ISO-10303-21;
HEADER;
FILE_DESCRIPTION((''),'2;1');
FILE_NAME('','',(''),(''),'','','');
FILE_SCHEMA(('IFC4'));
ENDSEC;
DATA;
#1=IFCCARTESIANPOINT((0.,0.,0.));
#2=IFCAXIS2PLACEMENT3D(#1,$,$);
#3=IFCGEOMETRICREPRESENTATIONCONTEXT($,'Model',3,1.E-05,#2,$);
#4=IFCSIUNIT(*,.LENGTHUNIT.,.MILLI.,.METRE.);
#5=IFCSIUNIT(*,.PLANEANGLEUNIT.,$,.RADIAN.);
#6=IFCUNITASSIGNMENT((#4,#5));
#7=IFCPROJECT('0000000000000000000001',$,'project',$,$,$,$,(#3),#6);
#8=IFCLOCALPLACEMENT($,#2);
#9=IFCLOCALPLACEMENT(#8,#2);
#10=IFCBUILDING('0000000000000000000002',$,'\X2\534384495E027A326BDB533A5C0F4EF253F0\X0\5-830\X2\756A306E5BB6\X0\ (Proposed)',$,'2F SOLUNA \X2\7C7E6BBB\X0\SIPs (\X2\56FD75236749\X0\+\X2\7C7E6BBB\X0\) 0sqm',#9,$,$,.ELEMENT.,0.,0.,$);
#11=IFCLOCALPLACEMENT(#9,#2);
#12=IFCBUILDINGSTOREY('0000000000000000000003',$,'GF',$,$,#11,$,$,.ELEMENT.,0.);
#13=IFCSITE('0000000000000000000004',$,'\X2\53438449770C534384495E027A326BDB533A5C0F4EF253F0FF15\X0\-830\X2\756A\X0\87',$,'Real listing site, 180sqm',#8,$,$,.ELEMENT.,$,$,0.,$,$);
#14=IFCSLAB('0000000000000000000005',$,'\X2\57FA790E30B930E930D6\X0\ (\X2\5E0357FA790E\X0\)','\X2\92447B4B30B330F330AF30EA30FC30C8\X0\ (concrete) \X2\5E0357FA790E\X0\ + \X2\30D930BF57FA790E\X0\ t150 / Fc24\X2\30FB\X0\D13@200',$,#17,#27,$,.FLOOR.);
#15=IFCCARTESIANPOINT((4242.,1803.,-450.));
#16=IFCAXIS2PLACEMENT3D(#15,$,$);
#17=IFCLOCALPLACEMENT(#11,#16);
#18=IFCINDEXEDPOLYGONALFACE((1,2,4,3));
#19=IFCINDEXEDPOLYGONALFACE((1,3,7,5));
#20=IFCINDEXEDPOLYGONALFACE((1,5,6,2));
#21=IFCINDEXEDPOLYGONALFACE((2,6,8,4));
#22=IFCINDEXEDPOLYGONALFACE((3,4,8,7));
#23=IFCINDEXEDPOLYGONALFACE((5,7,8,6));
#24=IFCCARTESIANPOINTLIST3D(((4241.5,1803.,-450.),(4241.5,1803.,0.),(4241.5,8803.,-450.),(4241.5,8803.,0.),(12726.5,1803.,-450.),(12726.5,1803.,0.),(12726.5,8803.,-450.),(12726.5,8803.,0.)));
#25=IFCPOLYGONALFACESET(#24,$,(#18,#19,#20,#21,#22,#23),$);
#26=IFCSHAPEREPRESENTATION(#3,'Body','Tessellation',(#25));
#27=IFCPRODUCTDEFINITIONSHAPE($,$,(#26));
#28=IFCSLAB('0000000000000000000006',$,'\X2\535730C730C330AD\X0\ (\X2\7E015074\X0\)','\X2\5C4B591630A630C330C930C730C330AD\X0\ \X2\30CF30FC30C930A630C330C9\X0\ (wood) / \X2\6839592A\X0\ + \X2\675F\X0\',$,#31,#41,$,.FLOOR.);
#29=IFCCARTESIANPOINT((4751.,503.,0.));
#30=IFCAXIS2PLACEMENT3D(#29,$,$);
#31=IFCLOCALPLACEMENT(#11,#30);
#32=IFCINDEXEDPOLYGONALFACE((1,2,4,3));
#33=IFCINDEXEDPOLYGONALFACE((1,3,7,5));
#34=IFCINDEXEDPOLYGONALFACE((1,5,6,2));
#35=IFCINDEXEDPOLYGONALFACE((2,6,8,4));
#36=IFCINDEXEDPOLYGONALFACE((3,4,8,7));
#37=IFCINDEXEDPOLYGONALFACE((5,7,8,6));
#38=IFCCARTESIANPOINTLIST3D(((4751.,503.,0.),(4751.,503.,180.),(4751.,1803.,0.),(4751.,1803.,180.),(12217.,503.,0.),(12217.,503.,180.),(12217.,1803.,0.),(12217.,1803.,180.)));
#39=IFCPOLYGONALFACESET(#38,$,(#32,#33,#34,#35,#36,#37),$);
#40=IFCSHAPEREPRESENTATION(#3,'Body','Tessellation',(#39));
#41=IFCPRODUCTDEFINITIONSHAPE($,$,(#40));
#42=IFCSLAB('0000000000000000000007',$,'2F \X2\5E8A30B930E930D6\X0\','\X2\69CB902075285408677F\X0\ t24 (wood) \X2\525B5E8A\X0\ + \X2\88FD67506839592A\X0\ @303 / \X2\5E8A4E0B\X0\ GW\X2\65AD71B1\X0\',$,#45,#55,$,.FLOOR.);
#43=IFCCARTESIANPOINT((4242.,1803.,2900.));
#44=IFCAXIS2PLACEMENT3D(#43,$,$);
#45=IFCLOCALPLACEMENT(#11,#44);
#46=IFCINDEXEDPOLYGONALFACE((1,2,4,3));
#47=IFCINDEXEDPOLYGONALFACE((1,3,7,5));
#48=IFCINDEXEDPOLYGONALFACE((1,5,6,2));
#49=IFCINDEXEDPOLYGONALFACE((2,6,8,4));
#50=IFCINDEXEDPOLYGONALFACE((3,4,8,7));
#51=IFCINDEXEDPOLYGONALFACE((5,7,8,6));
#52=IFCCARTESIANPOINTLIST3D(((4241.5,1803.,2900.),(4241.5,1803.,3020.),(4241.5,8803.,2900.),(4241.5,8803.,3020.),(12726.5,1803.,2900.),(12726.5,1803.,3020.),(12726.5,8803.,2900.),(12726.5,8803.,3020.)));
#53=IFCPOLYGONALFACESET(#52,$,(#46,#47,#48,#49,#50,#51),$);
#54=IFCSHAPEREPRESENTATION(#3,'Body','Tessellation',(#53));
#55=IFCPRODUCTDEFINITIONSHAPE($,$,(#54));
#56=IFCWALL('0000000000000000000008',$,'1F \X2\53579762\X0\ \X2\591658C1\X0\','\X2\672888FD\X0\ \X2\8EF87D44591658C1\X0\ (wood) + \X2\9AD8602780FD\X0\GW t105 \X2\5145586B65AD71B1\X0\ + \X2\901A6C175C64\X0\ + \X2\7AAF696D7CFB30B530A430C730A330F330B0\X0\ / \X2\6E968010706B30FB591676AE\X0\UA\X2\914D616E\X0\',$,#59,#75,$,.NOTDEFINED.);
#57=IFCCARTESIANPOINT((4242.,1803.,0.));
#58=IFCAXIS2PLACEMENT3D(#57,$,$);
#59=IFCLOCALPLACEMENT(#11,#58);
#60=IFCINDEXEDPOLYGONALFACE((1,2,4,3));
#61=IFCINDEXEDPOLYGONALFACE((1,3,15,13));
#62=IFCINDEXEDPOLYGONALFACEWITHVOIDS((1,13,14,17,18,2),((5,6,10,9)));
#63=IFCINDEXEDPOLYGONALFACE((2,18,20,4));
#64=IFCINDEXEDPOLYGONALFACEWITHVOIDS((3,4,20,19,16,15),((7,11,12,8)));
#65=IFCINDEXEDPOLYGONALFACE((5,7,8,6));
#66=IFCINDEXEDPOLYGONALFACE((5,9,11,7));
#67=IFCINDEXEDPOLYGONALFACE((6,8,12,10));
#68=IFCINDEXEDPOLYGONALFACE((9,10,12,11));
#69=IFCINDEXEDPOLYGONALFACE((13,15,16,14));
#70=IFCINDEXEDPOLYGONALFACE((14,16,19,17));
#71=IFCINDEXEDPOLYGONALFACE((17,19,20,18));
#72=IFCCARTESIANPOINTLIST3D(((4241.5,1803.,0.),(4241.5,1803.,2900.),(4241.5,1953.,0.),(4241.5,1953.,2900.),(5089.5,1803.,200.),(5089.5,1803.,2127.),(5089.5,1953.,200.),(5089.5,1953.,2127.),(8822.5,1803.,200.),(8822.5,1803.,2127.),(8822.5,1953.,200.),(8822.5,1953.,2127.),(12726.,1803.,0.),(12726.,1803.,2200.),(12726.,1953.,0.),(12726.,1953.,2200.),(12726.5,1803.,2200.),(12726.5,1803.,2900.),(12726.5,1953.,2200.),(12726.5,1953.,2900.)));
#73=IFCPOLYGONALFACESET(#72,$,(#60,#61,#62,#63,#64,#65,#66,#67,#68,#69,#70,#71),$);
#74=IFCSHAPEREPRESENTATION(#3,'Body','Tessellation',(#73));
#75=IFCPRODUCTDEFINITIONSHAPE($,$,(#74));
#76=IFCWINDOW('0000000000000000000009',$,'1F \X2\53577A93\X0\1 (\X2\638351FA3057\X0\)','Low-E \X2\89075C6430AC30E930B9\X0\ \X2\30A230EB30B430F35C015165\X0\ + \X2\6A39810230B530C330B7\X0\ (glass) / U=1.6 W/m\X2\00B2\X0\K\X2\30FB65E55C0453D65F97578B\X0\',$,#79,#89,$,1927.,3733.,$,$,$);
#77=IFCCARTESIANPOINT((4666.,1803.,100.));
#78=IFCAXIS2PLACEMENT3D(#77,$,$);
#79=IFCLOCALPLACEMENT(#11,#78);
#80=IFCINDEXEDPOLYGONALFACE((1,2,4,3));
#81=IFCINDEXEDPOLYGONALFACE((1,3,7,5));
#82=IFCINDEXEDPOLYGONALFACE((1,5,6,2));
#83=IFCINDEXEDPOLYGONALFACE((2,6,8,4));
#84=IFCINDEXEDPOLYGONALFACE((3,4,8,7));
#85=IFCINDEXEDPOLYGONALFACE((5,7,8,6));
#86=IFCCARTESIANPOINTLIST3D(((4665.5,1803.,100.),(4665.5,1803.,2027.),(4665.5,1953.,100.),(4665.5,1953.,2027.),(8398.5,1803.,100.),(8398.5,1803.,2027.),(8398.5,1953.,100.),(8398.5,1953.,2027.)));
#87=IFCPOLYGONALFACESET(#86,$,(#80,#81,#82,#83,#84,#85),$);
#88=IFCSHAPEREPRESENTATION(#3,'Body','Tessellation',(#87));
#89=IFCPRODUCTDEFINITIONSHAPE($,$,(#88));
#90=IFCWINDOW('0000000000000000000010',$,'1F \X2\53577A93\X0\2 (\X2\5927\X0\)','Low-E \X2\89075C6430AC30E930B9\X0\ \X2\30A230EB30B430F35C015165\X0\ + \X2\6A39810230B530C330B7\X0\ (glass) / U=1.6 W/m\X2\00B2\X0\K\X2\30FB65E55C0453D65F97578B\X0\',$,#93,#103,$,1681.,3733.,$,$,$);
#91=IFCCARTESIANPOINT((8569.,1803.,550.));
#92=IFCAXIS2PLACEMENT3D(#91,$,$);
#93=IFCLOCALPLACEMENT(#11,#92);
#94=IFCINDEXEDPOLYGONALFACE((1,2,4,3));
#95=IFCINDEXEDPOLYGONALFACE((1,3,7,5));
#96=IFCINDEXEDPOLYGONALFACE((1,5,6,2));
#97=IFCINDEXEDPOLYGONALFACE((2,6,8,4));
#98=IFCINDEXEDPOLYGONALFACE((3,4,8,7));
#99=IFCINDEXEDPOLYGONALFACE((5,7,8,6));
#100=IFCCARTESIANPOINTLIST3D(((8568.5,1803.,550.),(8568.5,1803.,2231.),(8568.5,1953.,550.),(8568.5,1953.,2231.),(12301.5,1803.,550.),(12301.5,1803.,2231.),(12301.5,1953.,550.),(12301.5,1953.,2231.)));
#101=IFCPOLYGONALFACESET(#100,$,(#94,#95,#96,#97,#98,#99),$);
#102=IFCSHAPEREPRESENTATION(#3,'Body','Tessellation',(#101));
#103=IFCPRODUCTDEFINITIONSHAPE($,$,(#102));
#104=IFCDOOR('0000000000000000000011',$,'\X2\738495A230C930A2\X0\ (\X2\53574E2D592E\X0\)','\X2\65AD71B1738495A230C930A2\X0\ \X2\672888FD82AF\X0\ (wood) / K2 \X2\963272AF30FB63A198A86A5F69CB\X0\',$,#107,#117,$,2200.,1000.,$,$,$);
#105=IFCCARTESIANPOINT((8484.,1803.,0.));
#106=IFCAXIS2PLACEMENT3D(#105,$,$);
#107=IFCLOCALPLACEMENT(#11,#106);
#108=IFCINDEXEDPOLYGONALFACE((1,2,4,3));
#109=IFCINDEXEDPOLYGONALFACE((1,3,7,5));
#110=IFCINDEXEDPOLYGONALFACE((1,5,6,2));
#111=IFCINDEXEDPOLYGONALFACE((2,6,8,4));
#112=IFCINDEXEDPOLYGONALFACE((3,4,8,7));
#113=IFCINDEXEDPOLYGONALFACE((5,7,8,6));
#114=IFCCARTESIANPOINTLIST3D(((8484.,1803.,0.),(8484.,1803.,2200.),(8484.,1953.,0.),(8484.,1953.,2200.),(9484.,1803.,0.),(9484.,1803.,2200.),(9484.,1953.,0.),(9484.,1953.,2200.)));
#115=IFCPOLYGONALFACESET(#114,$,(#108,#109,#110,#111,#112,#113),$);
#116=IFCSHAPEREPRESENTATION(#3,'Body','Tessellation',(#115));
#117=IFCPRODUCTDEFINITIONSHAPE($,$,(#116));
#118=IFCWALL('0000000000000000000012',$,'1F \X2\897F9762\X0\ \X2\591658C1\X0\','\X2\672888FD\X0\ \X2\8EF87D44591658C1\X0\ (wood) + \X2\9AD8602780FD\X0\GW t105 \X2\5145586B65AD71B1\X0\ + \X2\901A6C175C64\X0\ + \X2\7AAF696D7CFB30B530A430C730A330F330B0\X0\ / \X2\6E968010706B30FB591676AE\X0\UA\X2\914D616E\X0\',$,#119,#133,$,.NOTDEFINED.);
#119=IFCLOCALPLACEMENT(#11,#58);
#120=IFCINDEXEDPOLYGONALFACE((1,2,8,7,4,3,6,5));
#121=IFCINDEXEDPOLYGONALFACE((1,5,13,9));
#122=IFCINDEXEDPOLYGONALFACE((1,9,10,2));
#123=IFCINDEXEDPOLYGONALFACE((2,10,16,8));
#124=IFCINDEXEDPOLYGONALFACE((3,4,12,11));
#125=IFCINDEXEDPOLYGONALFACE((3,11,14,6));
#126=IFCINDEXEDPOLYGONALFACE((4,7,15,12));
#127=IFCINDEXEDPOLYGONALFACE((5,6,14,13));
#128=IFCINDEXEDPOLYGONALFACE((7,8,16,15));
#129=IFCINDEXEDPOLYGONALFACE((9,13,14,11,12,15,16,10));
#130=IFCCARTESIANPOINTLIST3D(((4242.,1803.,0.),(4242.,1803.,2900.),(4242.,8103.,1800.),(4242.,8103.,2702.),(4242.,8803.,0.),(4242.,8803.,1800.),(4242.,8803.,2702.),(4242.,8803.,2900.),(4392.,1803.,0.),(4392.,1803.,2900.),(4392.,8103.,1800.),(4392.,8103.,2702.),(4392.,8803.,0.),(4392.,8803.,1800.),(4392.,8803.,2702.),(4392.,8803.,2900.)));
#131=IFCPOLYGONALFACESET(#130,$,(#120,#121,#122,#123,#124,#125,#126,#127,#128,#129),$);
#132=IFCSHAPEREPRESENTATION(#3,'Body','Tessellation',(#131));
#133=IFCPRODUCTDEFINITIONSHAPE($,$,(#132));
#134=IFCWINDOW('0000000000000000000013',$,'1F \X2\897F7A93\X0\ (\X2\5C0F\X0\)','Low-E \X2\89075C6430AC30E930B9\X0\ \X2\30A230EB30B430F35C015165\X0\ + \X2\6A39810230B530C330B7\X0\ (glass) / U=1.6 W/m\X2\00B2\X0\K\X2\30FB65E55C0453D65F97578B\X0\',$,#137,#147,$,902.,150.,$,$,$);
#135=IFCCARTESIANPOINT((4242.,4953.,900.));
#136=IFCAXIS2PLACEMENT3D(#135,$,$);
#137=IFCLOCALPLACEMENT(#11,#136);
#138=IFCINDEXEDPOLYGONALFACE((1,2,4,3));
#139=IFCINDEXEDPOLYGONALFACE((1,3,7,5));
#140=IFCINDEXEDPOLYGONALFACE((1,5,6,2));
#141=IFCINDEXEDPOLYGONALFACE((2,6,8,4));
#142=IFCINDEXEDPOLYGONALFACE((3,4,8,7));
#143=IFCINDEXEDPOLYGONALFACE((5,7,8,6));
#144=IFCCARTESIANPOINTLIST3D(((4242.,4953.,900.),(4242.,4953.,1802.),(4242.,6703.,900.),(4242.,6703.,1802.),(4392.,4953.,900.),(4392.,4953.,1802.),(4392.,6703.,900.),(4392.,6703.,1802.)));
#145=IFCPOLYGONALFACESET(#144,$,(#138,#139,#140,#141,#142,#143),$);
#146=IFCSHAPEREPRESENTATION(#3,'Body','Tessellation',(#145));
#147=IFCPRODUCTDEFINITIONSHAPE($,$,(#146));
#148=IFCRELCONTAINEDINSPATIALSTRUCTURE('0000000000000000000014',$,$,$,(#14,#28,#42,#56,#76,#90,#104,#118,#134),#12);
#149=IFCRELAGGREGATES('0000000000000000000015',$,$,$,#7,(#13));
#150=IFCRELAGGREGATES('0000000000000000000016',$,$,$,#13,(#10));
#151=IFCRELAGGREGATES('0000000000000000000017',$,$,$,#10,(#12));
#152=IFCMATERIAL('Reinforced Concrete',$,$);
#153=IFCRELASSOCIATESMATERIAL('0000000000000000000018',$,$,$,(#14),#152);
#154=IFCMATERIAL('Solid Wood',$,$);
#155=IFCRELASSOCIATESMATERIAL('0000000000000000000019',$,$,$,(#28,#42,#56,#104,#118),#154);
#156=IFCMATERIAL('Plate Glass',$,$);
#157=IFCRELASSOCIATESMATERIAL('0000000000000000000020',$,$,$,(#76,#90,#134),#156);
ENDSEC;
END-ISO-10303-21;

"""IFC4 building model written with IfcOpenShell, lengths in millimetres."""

from ifc_helpers import new_model, si_unit, frame, frame_2d, origin, place, context, project, spatial, rectangle, extrude, material, element, fill, save


model = new_model("IFC4")

# Units and contexts
model_context = context("Model", 3, precision=1e-05, world=origin())
ifc_project = project(units=[si_unit("LENGTHUNIT", "METRE", prefix="MILLI"), si_unit("PLANEANGLEUNIT", "RADIAN")], contexts=[model_context])

# Site, building, storey
site_placement = place(None, origin())
site = spatial("IfcSite", under=ifc_project, at=site_placement, Name="千葉県千葉市稲毛区小仲台５-830番87", ObjectType="Real listing site, 180sqm", CompositionType="ELEMENT", RefElevation=0.0)
building_placement = place(site_placement, origin())
building = spatial("IfcBuilding", under=site, at=building_placement, Name="千葉市稲毛区小仲台5-830番の家 (Proposed)", ObjectType="2F SOLUNA 籾殻SIPs (国産杉+籾殻) 0sqm", CompositionType="ELEMENT", ElevationOfRefHeight=0.0, ElevationOfTerrain=0.0)
storey_placement = place(building_placement, origin())
storey = spatial("IfcBuildingStorey", under=building, at=storey_placement, Name="GF", CompositionType="ELEMENT", Elevation=0.0)

# Slabs
ifc_material_1 = material(Name="Reinforced Concrete")
slab_1_placement = place(storey_placement, frame((4242.0, 1803.0, -450.0)))
element("IfcSlab", 1, at=slab_1_placement, inside=storey, material=ifc_material_1, Name="基礎スラブ (布基礎)", Description="鉄筋コンクリート (concrete) 布基礎 + ベタ基礎 t150 / Fc24・D13@200", PredefinedType="FLOOR", context=model_context, shape_type="SweptSolid", body=[
    extrude(rectangle(XDim=8485.0, YDim=7000.0, at=frame_2d((4242.0, 3500.0))), frame((4242.0, 1803.0, -450.0)), (0.0, 0.0, 1.0), 450.0),
])
ifc_material_2 = material(Name="Solid Wood")
slab_2_placement = place(storey_placement, frame((4751.0, 503.0, 0.0)))
element("IfcSlab", 2, at=slab_2_placement, inside=storey, material=ifc_material_2, Name="南デッキ (縁側)", Description="屋外ウッドデッキ ハードウッド (wood) / 根太 + 束", PredefinedType="FLOOR", context=model_context, shape_type="SweptSolid", body=[
    extrude(rectangle(XDim=7466.0, YDim=1300.0, at=frame_2d((3733.0, 650.0))), frame((4751.0, 503.0, 0.0)), (0.0, 0.0, 1.0), 180.0),
])
slab_3_placement = place(storey_placement, frame((4242.0, 1803.0, 2900.0)))
element("IfcSlab", 3, at=slab_3_placement, inside=storey, material=ifc_material_2, Name="2F 床スラブ", Description="構造用合板 t24 (wood) 剛床 + 製材根太 @303 / 床下 GW断熱", PredefinedType="FLOOR", context=model_context, shape_type="SweptSolid", body=[
    extrude(rectangle(XDim=8485.0, YDim=7000.0, at=frame_2d((4242.0, 3500.0))), frame((4242.0, 1803.0, 2900.0)), (0.0, 0.0, 1.0), 120.0),
])

# Wall, openings, windows, door
wall_1_placement = place(storey_placement, frame((4242.0, 1803.0, 0.0)))
wall_1 = element("IfcWall", 4, at=wall_1_placement, inside=storey, material=ifc_material_2, Name="1F 南面 外壁", Description="木製 軸組外壁 (wood) + 高性能GW t105 充填断熱 + 通気層 + 窯業系サイディング / 準耐火・外皮UA配慮", PredefinedType="NOTDEFINED", context=model_context, shape_type="SweptSolid", body=[
    extrude(rectangle(XDim=8485.0, YDim=150.0, at=frame_2d((4242.0, 75.0))), frame((4242.0, 1803.0, 0.0)), (0.0, 0.0, 1.0), 2900.0),
])
opening_1_placement = place(storey_placement, frame((4666.0, 1803.0, 100.0)))
opening_1 = element("IfcOpeningElement", 5, at=opening_1_placement, cuts=wall_1, PredefinedType="NOTDEFINED", context=model_context, shape_type="SweptSolid", body=[
    extrude(rectangle(XDim=3733.0, YDim=150.0, at=frame_2d((1866.0, 75.0))), frame((4666.0, 1803.0, 100.0)), (0.0, 0.0, 1.0), 1927.0),
])
opening_2_placement = place(storey_placement, frame((8569.0, 1803.0, 550.0)))
opening_2 = element("IfcOpeningElement", 6, at=opening_2_placement, cuts=wall_1, PredefinedType="NOTDEFINED", context=model_context, shape_type="SweptSolid", body=[
    extrude(rectangle(XDim=3733.0, YDim=150.0, at=frame_2d((1866.0, 75.0))), frame((8569.0, 1803.0, 550.0)), (0.0, 0.0, 1.0), 1681.0),
])
opening_3_placement = place(storey_placement, frame((8484.0, 1803.0, 0.0)))
opening_3 = element("IfcOpeningElement", 7, at=opening_3_placement, cuts=wall_1, PredefinedType="NOTDEFINED", context=model_context, shape_type="SweptSolid", body=[
    extrude(rectangle(XDim=1000.0, YDim=150.0, at=frame_2d((500.0, 75.0))), frame((8484.0, 1803.0, 0.0)), (0.0, 0.0, 1.0), 2200.0),
])
ifc_material_3 = material(Name="Plate Glass")
window_1_placement = place(storey_placement, frame((4666.0, 1803.0, 100.0)))
window_1 = element("IfcWindow", 8, at=window_1_placement, inside=storey, material=ifc_material_3, Name="1F 南窓1 (掃出し)", Description="Low-E 複層ガラス アルゴン封入 + 樹脂サッシ (glass) / U=1.6 W/m²K・日射取得型", OverallHeight=1927.0, OverallWidth=3733.0, context=model_context, shape_type="SweptSolid", body=[
    extrude(rectangle(XDim=3733.0, YDim=150.0, at=frame_2d((1866.0, 75.0))), frame((4666.0, 1803.0, 100.0)), (0.0, 0.0, 1.0), 1927.0),
])
fill(opening_1, window_1)
window_2_placement = place(storey_placement, frame((8569.0, 1803.0, 550.0)))
window_2 = element("IfcWindow", 9, at=window_2_placement, inside=storey, material=ifc_material_3, Name="1F 南窓2 (大)", Description="Low-E 複層ガラス アルゴン封入 + 樹脂サッシ (glass) / U=1.6 W/m²K・日射取得型", OverallHeight=1681.0, OverallWidth=3733.0, context=model_context, shape_type="SweptSolid", body=[
    extrude(rectangle(XDim=3733.0, YDim=150.0, at=frame_2d((1866.0, 75.0))), frame((8569.0, 1803.0, 550.0)), (0.0, 0.0, 1.0), 1681.0),
])
fill(opening_2, window_2)
door_placement = place(storey_placement, frame((8484.0, 1803.0, 0.0)))
door = element("IfcDoor", 10, at=door_placement, inside=storey, material=ifc_material_2, Name="玄関ドア (南中央)", Description="断熱玄関ドア 木製芯 (wood) / K2 防犯・採風機構", OverallHeight=2200.0, OverallWidth=1000.0, context=model_context, shape_type="SweptSolid", body=[
    extrude(rectangle(XDim=1000.0, YDim=150.0, at=frame_2d((500.0, 75.0))), frame((8484.0, 1803.0, 0.0)), (0.0, 0.0, 1.0), 2200.0),
])
fill(opening_3, door)

# Wall, opening, window
wall_2_placement = place(storey_placement, frame((4242.0, 1803.0, 0.0)))
wall_2 = element("IfcWall", 11, at=wall_2_placement, inside=storey, material=ifc_material_2, Name="1F 西面 外壁", Description="木製 軸組外壁 (wood) + 高性能GW t105 充填断熱 + 通気層 + 窯業系サイディング / 準耐火・外皮UA配慮", PredefinedType="NOTDEFINED", context=model_context, shape_type="SweptSolid", body=[
    extrude(rectangle(XDim=150.0, YDim=7000.0, at=frame_2d((75.0, 3500.0))), frame((4242.0, 1803.0, 0.0)), (0.0, 0.0, 1.0), 2900.0),
])
opening_4_placement = place(storey_placement, frame((4242.0, 4953.0, 900.0)))
opening_4 = element("IfcOpeningElement", 12, at=opening_4_placement, cuts=wall_2, PredefinedType="NOTDEFINED", context=model_context, shape_type="SweptSolid", body=[
    extrude(rectangle(XDim=150.0, YDim=1750.0, at=frame_2d((75.0, 875.0))), frame((4242.0, 4953.0, 900.0)), (0.0, 0.0, 1.0), 902.0),
])
window_3_placement = place(storey_placement, frame((4242.0, 4953.0, 900.0)))
window_3 = element("IfcWindow", 13, at=window_3_placement, inside=storey, material=ifc_material_3, Name="1F 西窓 (小)", Description="Low-E 複層ガラス アルゴン封入 + 樹脂サッシ (glass) / U=1.6 W/m²K・日射取得型", OverallHeight=902.0, OverallWidth=150.0, context=model_context, shape_type="SweptSolid", body=[
    extrude(rectangle(XDim=150.0, YDim=1750.0, at=frame_2d((75.0, 875.0))), frame((4242.0, 4953.0, 900.0)), (0.0, 0.0, 1.0), 902.0),
])
fill(opening_4, window_3)

save(model, "model.ifc")
